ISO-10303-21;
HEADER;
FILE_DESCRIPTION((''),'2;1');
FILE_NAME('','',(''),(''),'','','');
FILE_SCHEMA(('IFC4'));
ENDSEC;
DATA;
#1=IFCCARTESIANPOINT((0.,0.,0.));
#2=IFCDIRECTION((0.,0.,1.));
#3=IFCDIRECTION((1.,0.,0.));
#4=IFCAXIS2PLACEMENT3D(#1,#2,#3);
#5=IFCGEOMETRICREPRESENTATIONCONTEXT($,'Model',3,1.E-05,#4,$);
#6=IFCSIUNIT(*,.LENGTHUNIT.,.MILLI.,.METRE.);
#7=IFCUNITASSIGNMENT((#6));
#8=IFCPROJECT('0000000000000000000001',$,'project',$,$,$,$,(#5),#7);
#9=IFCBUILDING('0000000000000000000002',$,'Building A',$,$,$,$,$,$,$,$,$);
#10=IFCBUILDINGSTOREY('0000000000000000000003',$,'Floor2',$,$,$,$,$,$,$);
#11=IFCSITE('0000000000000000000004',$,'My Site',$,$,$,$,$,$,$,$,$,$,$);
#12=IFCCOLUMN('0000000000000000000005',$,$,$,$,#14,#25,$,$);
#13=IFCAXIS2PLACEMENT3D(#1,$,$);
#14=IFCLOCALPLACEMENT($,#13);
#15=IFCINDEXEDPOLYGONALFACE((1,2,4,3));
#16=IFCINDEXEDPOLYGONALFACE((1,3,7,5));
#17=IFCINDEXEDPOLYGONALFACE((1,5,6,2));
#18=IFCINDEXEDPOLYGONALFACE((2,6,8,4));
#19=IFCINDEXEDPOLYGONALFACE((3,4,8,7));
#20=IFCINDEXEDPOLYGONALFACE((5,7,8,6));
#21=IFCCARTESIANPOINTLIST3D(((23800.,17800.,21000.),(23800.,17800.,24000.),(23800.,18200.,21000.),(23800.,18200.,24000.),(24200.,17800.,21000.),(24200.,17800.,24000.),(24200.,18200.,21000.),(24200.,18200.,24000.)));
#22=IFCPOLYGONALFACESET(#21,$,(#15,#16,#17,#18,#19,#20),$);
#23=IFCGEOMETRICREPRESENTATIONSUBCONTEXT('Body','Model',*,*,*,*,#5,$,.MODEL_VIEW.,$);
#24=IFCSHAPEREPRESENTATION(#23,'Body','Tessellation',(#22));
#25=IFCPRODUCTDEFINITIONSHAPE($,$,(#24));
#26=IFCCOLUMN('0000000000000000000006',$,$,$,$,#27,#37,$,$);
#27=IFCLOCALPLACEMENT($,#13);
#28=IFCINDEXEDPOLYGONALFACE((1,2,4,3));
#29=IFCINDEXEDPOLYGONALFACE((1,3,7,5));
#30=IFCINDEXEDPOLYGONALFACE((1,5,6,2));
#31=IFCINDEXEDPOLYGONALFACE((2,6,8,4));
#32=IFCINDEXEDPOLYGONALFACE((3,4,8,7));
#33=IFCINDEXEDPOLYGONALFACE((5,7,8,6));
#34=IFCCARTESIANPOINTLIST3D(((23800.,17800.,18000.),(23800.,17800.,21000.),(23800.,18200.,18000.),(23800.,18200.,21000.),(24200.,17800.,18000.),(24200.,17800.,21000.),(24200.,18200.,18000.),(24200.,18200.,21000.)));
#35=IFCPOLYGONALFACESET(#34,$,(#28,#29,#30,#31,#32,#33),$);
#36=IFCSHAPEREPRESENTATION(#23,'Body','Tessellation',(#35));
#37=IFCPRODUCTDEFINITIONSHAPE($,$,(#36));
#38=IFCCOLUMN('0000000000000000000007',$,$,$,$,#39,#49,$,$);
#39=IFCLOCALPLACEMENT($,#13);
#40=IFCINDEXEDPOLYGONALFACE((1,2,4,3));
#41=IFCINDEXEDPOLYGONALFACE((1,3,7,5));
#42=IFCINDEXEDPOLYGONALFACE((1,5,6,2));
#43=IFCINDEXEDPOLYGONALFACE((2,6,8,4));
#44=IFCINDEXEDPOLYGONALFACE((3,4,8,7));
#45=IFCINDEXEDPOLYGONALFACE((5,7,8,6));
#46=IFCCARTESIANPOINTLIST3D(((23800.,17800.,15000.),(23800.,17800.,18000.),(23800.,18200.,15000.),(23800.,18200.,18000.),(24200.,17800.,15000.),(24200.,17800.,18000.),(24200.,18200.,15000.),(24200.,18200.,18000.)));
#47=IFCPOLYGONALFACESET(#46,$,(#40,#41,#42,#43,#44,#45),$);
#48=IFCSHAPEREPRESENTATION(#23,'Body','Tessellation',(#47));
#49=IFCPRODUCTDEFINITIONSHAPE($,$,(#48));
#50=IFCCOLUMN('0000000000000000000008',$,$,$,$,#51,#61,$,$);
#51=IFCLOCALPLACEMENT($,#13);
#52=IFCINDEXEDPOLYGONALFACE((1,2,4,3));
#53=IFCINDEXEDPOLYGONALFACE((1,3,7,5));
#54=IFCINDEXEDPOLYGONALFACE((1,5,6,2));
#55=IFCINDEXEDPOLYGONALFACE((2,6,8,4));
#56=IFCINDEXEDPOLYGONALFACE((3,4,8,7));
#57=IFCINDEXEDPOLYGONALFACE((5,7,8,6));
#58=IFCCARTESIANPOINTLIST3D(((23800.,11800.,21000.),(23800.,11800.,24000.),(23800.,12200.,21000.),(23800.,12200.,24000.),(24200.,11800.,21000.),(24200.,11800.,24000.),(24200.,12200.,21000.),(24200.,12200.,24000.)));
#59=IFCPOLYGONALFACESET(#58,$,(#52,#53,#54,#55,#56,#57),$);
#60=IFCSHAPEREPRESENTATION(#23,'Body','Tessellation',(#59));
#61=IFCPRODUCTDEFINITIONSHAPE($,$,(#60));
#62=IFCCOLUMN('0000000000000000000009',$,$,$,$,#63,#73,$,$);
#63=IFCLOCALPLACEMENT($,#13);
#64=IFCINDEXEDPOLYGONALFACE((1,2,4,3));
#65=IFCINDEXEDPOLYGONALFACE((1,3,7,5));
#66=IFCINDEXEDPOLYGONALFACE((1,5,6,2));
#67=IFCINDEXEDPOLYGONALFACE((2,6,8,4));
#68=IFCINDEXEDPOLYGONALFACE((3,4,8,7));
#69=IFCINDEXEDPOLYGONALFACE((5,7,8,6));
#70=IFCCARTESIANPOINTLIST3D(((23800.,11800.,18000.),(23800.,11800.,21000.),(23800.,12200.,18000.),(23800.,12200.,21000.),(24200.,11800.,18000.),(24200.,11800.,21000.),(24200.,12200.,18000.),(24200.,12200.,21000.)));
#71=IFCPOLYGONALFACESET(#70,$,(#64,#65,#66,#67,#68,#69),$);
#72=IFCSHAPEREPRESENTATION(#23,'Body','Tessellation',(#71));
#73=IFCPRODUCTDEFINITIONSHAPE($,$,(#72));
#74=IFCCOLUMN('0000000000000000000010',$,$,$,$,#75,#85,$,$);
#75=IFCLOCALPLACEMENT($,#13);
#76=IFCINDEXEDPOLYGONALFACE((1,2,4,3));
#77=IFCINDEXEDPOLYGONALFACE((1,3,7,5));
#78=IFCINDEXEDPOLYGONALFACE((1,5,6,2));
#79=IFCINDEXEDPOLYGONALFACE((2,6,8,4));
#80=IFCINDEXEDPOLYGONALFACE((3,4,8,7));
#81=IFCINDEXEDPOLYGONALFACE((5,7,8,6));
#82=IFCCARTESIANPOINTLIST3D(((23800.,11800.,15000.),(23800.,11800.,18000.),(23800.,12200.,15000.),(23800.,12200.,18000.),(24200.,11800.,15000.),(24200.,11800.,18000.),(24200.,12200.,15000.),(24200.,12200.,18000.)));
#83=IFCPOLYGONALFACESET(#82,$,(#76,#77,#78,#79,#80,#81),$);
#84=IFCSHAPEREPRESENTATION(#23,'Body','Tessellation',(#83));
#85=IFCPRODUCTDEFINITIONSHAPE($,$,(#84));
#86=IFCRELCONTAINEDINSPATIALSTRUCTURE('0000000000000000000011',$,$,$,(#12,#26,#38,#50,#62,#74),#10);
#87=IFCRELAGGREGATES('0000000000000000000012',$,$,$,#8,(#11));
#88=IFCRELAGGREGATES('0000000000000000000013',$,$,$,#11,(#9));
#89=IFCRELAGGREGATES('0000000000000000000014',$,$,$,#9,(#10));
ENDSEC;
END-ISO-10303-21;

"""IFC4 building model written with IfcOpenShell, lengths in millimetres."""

from ifc_helpers import new_model, si_unit, frame, origin_with_axes, place, context, subcontext, project, spatial, line, indexed_curve, outline, extrude, element, save


model = new_model("IFC4")

# Units and contexts
model_context = context("Model", 3, precision=1e-05, world=origin_with_axes())
body_context = subcontext(model_context, "Body", "Model", "MODEL_VIEW")
ifc_project = project(units=[si_unit("LENGTHUNIT", "METRE", prefix="MILLI")], contexts=[model_context])

# Site, building, storey
site = spatial("IfcSite", under=ifc_project, Name="My Site")
building = spatial("IfcBuilding", under=site, Name="Building A")
storey = spatial("IfcBuildingStorey", under=building, Name="Floor2")

# Columns
for number, where, z_axis, x_axis in (
    (1, (24000.0, 18000.0, 21000.0), (0.0, 0.0, 1.0), (1.0, 0.0, 0.0)),
    (2, (24000.0, 18000.0, 18000.0), (0.0, 0.0, 1.0), (1.0, 0.0, 0.0)),
    (3, (24000.0, 18000.0, 15000.0), (0.0, 0.0, 1.0), (1.0, 0.0, 0.0)),
    (4, (24000.0, 12000.0, 21000.0), (0.0, 0.0, 1.0), (1.0, 0.0, 0.0)),
    (5, (24000.0, 12000.0, 18000.0), (0.0, 0.0, 1.0), (1.0, 0.0, 0.0)),
    (6, (24000.0, 12000.0, 15000.0), (0.0, 0.0, 1.0), (1.0, 0.0, 0.0)),
):
    element("IfcColumn", number, at=place(None, frame(where, z_axis=z_axis, x_axis=x_axis)), inside=storey, context=body_context, shape_type="SweptSolid", body=[
        extrude(outline(indexed_curve([(-200.0, -200.0), (200.0, -200.0), (200.0, 200.0), (-200.0, 200.0)], segments=[line(1, 2, 3, 4, 1)])), origin_with_axes(), (0.0, 0.0, 1.0), 3000.0),
    ])

save(model, "model.ifc")
